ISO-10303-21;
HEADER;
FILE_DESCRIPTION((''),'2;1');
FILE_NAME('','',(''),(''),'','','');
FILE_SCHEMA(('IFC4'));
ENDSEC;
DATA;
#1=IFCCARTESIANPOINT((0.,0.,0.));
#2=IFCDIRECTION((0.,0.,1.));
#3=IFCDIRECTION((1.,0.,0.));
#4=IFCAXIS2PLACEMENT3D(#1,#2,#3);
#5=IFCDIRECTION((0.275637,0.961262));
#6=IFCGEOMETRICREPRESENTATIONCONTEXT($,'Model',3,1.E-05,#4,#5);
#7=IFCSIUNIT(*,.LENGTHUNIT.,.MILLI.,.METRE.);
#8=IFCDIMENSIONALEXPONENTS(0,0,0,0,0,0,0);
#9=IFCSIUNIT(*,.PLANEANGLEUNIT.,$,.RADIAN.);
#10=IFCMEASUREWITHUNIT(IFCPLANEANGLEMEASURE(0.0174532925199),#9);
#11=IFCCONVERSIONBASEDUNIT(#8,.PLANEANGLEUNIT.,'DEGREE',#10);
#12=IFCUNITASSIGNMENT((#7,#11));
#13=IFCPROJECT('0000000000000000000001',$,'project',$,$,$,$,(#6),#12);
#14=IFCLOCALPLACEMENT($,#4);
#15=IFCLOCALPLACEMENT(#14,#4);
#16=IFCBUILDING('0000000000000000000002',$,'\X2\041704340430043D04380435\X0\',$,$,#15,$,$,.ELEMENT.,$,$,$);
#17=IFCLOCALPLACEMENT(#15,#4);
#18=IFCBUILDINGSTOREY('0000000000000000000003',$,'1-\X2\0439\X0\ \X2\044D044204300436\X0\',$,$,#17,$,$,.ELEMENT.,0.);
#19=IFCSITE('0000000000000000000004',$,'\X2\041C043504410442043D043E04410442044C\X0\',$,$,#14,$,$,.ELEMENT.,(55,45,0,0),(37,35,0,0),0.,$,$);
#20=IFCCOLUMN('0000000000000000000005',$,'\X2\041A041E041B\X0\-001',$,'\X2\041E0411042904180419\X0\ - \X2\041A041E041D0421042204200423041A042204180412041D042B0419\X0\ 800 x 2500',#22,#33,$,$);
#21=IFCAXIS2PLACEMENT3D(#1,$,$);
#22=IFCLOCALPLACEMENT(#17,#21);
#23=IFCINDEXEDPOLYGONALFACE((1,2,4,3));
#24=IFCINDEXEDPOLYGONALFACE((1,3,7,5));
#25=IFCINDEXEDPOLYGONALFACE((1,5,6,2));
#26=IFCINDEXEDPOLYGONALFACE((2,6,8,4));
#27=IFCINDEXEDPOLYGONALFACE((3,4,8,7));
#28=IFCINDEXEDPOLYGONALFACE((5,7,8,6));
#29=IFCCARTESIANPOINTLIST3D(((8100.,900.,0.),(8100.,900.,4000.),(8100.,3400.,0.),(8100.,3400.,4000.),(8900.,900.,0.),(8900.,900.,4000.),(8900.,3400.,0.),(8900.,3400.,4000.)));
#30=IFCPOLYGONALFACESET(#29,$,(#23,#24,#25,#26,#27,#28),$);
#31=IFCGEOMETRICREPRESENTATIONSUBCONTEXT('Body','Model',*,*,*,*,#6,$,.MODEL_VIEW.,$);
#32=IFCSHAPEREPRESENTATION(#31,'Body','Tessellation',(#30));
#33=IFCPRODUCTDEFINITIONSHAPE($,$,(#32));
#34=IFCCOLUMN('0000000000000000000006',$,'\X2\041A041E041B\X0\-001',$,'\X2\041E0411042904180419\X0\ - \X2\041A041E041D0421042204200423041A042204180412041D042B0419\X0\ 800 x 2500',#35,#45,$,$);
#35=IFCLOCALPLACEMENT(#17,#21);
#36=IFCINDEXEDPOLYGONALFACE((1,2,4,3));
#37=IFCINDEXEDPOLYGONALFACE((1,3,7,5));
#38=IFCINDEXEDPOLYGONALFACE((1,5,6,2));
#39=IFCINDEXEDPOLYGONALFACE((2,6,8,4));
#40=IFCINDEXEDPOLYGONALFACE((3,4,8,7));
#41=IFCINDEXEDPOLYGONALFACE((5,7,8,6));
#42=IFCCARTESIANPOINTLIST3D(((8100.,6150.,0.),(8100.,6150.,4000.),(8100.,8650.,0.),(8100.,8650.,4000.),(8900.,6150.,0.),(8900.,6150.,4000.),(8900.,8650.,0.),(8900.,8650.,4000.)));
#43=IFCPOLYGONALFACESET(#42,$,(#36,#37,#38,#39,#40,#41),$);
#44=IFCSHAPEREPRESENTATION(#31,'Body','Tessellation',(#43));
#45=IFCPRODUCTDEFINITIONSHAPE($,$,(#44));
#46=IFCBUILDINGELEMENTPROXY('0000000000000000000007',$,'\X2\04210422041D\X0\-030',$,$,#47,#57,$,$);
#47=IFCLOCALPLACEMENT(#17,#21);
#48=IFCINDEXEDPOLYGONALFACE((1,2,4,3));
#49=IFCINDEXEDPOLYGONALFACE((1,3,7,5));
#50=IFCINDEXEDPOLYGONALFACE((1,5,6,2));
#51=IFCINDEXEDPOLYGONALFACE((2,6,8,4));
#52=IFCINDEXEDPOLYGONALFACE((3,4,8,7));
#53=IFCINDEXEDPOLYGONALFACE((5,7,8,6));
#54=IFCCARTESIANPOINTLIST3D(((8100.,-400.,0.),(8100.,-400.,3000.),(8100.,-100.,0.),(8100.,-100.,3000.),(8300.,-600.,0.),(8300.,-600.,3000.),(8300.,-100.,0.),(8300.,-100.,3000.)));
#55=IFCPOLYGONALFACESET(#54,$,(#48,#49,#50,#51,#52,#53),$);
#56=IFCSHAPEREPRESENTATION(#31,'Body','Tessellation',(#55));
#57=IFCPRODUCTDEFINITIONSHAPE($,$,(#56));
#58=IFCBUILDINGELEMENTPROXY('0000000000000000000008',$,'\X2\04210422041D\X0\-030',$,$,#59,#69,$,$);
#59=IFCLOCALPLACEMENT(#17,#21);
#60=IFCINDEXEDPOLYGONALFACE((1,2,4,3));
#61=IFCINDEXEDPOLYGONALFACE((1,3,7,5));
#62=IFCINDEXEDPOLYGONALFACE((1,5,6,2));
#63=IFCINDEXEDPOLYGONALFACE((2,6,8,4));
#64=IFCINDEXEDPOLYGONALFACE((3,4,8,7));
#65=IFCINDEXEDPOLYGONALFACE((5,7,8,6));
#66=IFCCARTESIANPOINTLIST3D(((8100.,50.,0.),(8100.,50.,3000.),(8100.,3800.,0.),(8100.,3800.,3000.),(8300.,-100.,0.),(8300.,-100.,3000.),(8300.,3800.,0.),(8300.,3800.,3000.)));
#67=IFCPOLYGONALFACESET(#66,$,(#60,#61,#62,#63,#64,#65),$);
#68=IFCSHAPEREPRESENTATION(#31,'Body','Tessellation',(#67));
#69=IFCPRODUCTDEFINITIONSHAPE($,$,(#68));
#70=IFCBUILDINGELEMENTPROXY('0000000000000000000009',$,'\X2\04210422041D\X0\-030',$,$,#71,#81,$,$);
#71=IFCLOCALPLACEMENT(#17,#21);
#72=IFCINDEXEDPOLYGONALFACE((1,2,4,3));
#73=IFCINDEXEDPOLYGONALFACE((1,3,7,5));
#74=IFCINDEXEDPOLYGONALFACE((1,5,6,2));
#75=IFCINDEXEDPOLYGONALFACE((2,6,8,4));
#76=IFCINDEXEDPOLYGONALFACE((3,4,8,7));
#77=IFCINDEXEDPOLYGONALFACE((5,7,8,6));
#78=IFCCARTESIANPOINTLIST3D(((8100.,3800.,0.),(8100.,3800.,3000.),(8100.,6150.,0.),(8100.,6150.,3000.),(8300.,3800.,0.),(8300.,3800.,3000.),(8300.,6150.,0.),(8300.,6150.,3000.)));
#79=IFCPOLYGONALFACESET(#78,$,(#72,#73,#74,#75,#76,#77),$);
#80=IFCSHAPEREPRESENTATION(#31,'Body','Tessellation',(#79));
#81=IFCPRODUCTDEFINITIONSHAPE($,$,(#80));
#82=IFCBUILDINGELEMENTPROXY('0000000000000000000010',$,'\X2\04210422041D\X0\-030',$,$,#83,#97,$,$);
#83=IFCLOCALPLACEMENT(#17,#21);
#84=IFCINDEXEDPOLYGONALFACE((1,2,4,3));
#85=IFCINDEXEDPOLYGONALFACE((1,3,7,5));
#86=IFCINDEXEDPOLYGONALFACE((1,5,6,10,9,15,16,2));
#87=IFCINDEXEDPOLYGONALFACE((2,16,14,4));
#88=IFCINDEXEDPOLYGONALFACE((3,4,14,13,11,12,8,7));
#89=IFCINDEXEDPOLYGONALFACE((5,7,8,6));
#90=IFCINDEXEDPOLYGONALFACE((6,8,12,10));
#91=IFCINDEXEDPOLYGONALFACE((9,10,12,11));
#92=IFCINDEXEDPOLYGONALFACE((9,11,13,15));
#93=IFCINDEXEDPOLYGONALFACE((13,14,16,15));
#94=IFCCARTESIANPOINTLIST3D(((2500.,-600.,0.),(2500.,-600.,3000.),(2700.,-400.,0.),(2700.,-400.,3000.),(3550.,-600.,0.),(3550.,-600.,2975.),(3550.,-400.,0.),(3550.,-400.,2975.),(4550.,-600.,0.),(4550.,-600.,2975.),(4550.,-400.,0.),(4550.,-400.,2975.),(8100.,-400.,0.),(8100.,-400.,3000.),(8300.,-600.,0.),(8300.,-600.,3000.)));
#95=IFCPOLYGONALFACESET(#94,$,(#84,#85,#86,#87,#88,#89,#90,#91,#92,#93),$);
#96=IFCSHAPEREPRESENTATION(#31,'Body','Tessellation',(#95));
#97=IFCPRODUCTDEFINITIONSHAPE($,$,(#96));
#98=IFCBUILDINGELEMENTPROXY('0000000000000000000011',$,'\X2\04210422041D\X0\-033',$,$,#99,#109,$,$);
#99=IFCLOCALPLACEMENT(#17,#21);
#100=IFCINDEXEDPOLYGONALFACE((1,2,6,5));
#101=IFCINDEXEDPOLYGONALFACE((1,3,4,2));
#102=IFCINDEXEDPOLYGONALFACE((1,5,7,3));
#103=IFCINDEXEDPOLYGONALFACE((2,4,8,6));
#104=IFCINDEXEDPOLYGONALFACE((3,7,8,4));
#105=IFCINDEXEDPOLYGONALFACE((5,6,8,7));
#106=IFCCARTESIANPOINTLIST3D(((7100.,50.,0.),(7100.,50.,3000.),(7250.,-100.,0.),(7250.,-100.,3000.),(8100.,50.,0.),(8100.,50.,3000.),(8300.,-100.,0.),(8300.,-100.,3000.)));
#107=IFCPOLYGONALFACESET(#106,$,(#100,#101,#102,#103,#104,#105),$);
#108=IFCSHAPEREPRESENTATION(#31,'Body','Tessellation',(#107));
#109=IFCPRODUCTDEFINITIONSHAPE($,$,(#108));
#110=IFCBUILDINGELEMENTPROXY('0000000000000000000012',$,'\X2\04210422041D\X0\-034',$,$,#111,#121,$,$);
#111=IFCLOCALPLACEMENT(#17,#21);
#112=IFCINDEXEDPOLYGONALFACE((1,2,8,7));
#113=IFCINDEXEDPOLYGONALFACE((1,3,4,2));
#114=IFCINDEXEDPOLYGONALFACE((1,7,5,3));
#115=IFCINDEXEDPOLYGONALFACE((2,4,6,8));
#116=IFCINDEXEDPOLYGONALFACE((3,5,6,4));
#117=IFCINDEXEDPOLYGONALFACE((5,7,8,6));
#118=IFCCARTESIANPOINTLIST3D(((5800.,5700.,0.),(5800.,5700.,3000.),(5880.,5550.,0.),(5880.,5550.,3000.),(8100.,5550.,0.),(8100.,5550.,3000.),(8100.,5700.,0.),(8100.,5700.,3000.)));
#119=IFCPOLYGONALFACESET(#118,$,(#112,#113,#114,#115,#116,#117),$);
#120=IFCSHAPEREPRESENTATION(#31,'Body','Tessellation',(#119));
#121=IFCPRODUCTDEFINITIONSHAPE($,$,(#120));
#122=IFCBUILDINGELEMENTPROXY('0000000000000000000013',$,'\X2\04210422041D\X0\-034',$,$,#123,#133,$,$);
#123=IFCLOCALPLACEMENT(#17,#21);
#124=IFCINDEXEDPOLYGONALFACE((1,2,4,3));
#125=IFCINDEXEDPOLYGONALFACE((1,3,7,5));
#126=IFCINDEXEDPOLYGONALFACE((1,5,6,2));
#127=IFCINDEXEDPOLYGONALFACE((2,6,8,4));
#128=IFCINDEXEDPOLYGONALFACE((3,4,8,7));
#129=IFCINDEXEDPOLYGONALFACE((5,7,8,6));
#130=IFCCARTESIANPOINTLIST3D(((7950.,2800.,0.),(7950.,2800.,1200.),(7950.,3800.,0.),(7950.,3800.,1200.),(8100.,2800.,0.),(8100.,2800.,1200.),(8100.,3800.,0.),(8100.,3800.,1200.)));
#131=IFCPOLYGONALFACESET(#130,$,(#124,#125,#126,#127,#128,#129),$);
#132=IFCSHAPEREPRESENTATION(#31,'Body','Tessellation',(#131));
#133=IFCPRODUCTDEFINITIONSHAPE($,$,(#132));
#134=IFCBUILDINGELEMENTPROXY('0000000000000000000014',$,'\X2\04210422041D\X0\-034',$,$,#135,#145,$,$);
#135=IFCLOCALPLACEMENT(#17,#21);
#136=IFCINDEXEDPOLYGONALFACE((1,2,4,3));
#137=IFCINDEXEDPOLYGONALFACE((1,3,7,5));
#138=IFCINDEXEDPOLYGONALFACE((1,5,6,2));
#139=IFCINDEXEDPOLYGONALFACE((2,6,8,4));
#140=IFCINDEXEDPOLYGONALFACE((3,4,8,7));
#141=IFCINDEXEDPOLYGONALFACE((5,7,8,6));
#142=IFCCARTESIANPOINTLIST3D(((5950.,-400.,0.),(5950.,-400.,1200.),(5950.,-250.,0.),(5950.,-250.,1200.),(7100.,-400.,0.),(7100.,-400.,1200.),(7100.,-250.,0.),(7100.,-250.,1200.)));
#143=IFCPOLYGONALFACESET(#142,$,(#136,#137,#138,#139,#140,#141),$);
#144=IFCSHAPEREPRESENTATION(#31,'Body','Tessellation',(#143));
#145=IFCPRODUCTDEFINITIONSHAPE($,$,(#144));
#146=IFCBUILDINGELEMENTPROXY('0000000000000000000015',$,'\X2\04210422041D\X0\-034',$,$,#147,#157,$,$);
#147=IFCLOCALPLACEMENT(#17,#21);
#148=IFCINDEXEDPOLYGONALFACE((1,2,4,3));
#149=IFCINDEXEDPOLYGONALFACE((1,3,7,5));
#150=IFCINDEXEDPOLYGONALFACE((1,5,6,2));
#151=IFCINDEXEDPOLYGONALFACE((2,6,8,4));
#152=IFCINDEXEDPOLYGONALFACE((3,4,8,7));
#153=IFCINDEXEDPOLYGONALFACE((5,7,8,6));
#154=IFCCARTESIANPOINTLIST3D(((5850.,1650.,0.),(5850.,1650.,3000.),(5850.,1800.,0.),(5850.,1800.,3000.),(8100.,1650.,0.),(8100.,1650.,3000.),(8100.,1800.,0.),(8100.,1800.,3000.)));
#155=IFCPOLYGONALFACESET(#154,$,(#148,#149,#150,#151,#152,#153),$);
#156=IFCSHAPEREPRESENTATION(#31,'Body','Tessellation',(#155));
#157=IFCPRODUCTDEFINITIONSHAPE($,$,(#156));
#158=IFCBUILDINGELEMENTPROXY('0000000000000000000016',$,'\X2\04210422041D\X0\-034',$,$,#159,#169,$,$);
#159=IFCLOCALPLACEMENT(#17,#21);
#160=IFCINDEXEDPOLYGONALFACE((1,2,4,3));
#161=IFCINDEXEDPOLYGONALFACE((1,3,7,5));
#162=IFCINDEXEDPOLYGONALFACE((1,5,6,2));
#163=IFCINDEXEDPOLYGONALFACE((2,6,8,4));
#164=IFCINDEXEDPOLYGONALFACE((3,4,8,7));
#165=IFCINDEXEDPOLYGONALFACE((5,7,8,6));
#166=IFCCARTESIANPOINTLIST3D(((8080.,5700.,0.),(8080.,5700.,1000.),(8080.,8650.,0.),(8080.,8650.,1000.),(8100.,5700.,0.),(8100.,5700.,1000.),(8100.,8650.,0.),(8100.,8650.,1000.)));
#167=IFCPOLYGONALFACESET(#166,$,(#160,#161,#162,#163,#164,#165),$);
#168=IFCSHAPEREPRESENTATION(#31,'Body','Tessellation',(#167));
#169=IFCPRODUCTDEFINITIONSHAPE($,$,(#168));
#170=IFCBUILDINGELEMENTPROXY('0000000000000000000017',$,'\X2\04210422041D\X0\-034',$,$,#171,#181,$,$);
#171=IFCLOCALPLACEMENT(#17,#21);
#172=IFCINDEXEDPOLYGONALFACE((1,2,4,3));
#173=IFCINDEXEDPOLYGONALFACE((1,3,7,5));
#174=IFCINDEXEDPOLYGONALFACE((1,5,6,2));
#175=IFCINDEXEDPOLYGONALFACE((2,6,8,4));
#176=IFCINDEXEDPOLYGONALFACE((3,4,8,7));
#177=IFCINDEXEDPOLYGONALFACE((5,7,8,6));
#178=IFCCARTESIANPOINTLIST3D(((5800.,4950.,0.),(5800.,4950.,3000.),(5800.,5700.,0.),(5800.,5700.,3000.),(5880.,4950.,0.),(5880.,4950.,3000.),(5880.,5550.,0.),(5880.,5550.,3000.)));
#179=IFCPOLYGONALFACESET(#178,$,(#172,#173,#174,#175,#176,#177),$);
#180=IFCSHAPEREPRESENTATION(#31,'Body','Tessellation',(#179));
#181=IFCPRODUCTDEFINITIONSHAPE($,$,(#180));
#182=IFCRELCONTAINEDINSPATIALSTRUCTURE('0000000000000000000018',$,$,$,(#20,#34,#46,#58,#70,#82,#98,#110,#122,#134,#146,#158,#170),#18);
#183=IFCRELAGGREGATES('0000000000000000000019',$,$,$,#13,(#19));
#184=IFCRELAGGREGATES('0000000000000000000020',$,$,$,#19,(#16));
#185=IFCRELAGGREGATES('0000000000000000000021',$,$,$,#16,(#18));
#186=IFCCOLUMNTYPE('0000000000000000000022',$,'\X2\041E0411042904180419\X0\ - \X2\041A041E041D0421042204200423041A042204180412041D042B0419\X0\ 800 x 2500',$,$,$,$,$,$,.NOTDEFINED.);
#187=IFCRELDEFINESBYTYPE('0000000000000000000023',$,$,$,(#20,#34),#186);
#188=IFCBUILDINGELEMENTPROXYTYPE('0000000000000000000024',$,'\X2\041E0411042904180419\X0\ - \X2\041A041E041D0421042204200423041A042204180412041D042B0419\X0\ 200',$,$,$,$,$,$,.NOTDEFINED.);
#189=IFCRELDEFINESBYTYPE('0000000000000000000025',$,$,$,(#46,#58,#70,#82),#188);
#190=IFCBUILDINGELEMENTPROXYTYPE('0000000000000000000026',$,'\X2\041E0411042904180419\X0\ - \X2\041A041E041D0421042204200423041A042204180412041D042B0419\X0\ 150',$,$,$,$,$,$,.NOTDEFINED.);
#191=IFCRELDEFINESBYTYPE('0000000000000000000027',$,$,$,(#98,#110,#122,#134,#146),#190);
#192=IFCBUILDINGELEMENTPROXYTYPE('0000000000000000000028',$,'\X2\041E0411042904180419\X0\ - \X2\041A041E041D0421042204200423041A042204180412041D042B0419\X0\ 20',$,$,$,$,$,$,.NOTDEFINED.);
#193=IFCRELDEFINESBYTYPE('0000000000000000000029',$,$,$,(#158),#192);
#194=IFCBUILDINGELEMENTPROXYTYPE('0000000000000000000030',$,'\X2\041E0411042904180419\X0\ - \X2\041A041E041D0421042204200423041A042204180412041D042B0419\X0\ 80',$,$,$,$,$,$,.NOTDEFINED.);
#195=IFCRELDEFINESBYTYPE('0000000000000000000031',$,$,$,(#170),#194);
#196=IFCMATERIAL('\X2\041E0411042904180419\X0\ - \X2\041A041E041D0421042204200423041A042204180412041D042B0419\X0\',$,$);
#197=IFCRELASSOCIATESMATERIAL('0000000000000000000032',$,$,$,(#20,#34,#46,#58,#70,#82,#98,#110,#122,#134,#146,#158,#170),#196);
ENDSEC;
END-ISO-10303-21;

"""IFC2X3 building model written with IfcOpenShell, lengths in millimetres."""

from ifc_helpers import new_model, entity, si_unit, converted_unit, direction, frame, origin_with_axes, origin_2d_with_axis, place, context, subcontext, project, spatial, polyline, rectangle, outline, extrude, material, type_object, element, save


model = new_model("IFC2X3")

# Units and contexts
model_context = context("Model", 3, precision=1e-05, world=origin_with_axes(), true_north=direction((0.275637, 0.961262)))
body_context = subcontext(model_context, "Body", "Model", "MODEL_VIEW")
ifc_project = project(units=[si_unit("LENGTHUNIT", "METRE", prefix="MILLI"), converted_unit("PLANEANGLEUNIT", "DEGREE", entity("IfcPlaneAngleMeasure", 0.0174532925199), si_unit("PLANEANGLEUNIT", "RADIAN"), dimensions=[0, 0, 0, 0, 0, 0, 0])], contexts=[model_context])

# Site, building, storey
site_placement = place(None, origin_with_axes())
site = spatial("IfcSite", under=ifc_project, at=site_placement, Name="Местность", CompositionType="ELEMENT", RefLatitude=(55, 45, 0, 0), RefLongitude=(37, 35, 0, 0), RefElevation=0.0)
building_placement = place(site_placement, origin_with_axes())
building = spatial("IfcBuilding", under=site, at=building_placement, Name="Здание", CompositionType="ELEMENT")
storey_placement = place(building_placement, origin_with_axes())
storey = spatial("IfcBuildingStorey", under=building, at=storey_placement, Name="1-й этаж", CompositionType="ELEMENT", Elevation=0.0)

# Columns
ifc_material_1 = material(Name="ОБЩИЙ - КОНСТРУКТИВНЫЙ")
column_type = type_object("IfcColumnType", Name="ОБЩИЙ - КОНСТРУКТИВНЫЙ 800 x 2500", PredefinedType="NOTDEFINED")
for number, where, z_axis, x_axis, name in (
    (1, (8500.0, 2150.0, 0.0), (0.0, 0.0, 1.0), (1.0, 0.0, 0.0), "КОЛ-001"),
    (2, (8500.0, 7400.0, 0.0), (0.0, 0.0, 1.0), (1.0, 0.0, 0.0), "КОЛ-001"),
):
    element("IfcColumn", number, at=place(storey_placement, frame(where, z_axis=z_axis, x_axis=x_axis)), inside=storey, type_object=column_type, material=ifc_material_1, Name=name, ObjectType="ОБЩИЙ - КОНСТРУКТИВНЫЙ 800 x 2500", context=body_context, shape_type="SweptSolid", body=[
        extrude(rectangle(XDim=800.0, YDim=2500.0, at=origin_2d_with_axis()), origin_with_axes(), (0.0, 0.0, 1.0), 4000.0),
    ])

# Building element proxies
building_element_proxy_type_1 = type_object("IfcBuildingElementProxyType", Name="ОБЩИЙ - КОНСТРУКТИВНЫЙ 200", PredefinedType="NOTDEFINED")
proxy_1_placement = place(storey_placement, frame((8100.0, -100.0, 0.0), z_axis=(0.0, 0.0, 1.0), x_axis=(0.0, -1.0, 0.0)))
element("IfcBuildingElementProxy", 3, at=proxy_1_placement, inside=storey, type_object=building_element_proxy_type_1, material=ifc_material_1, Name="СТН-030", context=body_context, shape_type="SweptSolid", body=[
    extrude(outline(polyline([(0.0, 0.0), (300.0, 0.0), (500.0, 200.0), (0.0, 200.0), (0.0, 0.0)])), origin_with_axes(), (0.0, 0.0, 1.0), 3000.0),
])
proxy_2_placement = place(storey_placement, frame((8300.0, 3800.0, 0.0), z_axis=(0.0, 0.0, 1.0), x_axis=(0.0, -1.0, 0.0)))
element("IfcBuildingElementProxy", 4, at=proxy_2_placement, inside=storey, type_object=building_element_proxy_type_1, material=ifc_material_1, Name="СТН-030", context=body_context, shape_type="SweptSolid", body=[
    extrude(outline(polyline([(0.0, -200.0), (3750.0, -200.0), (3900.0, 0.0), (0.0, 0.0), (0.0, -200.0)])), origin_with_axes(), (0.0, 0.0, 1.0), 3000.0),
])
proxy_3_placement = place(storey_placement, frame((8300.0, 6150.0, 0.0), z_axis=(0.0, 0.0, 1.0), x_axis=(0.0, -1.0, 0.0)))
element("IfcBuildingElementProxy", 5, at=proxy_3_placement, inside=storey, type_object=building_element_proxy_type_1, material=ifc_material_1, Name="СТН-030", context=body_context, shape_type="SweptSolid", body=[
    extrude(outline(polyline([(0.0, -200.0), (2350.0, -200.0), (2350.0, 0.0), (0.0, 0.0), (0.0, -200.0)])), origin_with_axes(), (0.0, 0.0, 1.0), 3000.0),
])

# Building element proxy, opening
proxy_4_placement = place(storey_placement, frame((8100.0, -600.0, 0.0), z_axis=(0.0, 0.0, 1.0), x_axis=(-1.0, 0.0, 0.0)))
proxy_4 = element("IfcBuildingElementProxy", 6, at=proxy_4_placement, inside=storey, type_object=building_element_proxy_type_1, material=ifc_material_1, Name="СТН-030", context=body_context, shape_type="SweptSolid", body=[
    extrude(outline(polyline([(0.0, -200.0), (5400.0, -200.0), (5600.0, 0.0), (-200.0, 0.0), (0.0, -200.0)])), origin_with_axes(), (0.0, 0.0, 1.0), 3000.0),
])
opening_1_placement = place(proxy_4_placement, frame((4050.0, 0.0, 0.0), z_axis=(0.0, 0.0, 1.0), x_axis=(1.0, 0.0, 0.0)))
element("IfcOpeningElement", 7, at=opening_1_placement, cuts=proxy_4, context=body_context, shape_type="SweptSolid", body=[
    extrude(rectangle(XDim=1000.0, YDim=2975.0, at=origin_2d_with_axis()), frame((0.0, 200.0, 1487.5), z_axis=(0.0, 1.0, 0.0), x_axis=(1.0, 0.0, 0.0)), (0.0, 0.0, -1.0), 600.0),
    extrude(rectangle(XDim=1044.0, YDim=2997.0, at=origin_2d_with_axis()), frame((0.0, 0.0, 1498.5), z_axis=(0.0, 1.0, 0.0), x_axis=(1.0, 0.0, 0.0)), (0.0, 0.0, 1.0), 200.0),
    extrude(rectangle(XDim=1044.0, YDim=2997.0, at=origin_2d_with_axis()), frame((0.0, -200.0, 1498.5), z_axis=(0.0, -1.0, 0.0), x_axis=(1.0, 0.0, 0.0)), (0.0, 0.0, 1.0), 200.0),
])

# Building element proxies
building_element_proxy_type_2 = type_object("IfcBuildingElementProxyType", Name="ОБЩИЙ - КОНСТРУКТИВНЫЙ 150", PredefinedType="NOTDEFINED")
proxy_5_placement = place(storey_placement, frame((7250.0, -100.0, 0.0), z_axis=(0.0, 0.0, 1.0), x_axis=(1.0, 0.0, 0.0)))
element("IfcBuildingElementProxy", 8, at=proxy_5_placement, inside=storey, type_object=building_element_proxy_type_2, material=ifc_material_1, Name="СТН-033", context=body_context, shape_type="SweptSolid", body=[
    extrude(outline(polyline([(0.0, 0.0), (1050.0, 0.0), (850.0, 150.0), (-150.0, 150.0), (0.0, 0.0)])), origin_with_axes(), (0.0, 0.0, 1.0), 3000.0),
])
proxy_6_placement = place(storey_placement, frame((5800.0, 5550.0, 0.0), z_axis=(0.0, 0.0, 1.0), x_axis=(1.0, 0.0, 0.0)))
element("IfcBuildingElementProxy", 9, at=proxy_6_placement, inside=storey, type_object=building_element_proxy_type_2, material=ifc_material_1, Name="СТН-034", context=body_context, shape_type="SweptSolid", body=[
    extrude(outline(polyline([(80.0, 0.0), (2300.0, 0.0), (2300.0, 150.0), (0.0, 150.0), (80.0, 0.0)])), origin_with_axes(), (0.0, 0.0, 1.0), 3000.0),
])
proxy_7_placement = place(storey_placement, frame((8100.0, 2800.0, 0.0), z_axis=(0.0, 0.0, 1.0), x_axis=(0.0, 1.0, 0.0)))
element("IfcBuildingElementProxy", 10, at=proxy_7_placement, inside=storey, type_object=building_element_proxy_type_2, material=ifc_material_1, Name="СТН-034", context=body_context, shape_type="SweptSolid", body=[
    extrude(outline(polyline([(0.0, 0.0), (1000.0, 0.0), (1000.0, 150.0), (0.0, 150.0), (0.0, 0.0)])), origin_with_axes(), (0.0, 0.0, 1.0), 1200.0),
])
proxy_8_placement = place(storey_placement, frame((5950.0, -400.0, 0.0), z_axis=(0.0, 0.0, 1.0), x_axis=(1.0, 0.0, 0.0)))
element("IfcBuildingElementProxy", 11, at=proxy_8_placement, inside=storey, type_object=building_element_proxy_type_2, material=ifc_material_1, Name="СТН-034", context=body_context, shape_type="SweptSolid", body=[
    extrude(outline(polyline([(0.0, 0.0), (1150.0, 0.0), (1150.0, 150.0), (0.0, 150.0), (0.0, 0.0)])), origin_with_axes(), (0.0, 0.0, 1.0), 1200.0),
])
proxy_9_placement = place(storey_placement, frame((5850.0, 1800.0, 0.0), z_axis=(0.0, 0.0, 1.0), x_axis=(1.0, 0.0, 0.0)))
element("IfcBuildingElementProxy", 12, at=proxy_9_placement, inside=storey, type_object=building_element_proxy_type_2, material=ifc_material_1, Name="СТН-034", context=body_context, shape_type="SweptSolid", body=[
    extrude(outline(polyline([(0.0, -150.0), (2250.0, -150.0), (2250.0, 0.0), (0.0, 0.0), (0.0, -150.0)])), origin_with_axes(), (0.0, 0.0, 1.0), 3000.0),
])

# Building element proxies
building_element_proxy_type_3 = type_object("IfcBuildingElementProxyType", Name="ОБЩИЙ - КОНСТРУКТИВНЫЙ 20", PredefinedType="NOTDEFINED")
proxy_10_placement = place(storey_placement, frame((8100.0, 5700.0, 0.0), z_axis=(0.0, 0.0, 1.0), x_axis=(0.0, 1.0, 0.0)))
element("IfcBuildingElementProxy", 13, at=proxy_10_placement, inside=storey, type_object=building_element_proxy_type_3, material=ifc_material_1, Name="СТН-034", context=body_context, shape_type="SweptSolid", body=[
    extrude(outline(polyline([(0.0, 0.0), (2950.0, 0.0), (2950.0, 20.0), (0.0, 20.0), (0.0, 0.0)])), origin_with_axes(), (0.0, 0.0, 1.0), 1000.0),
])
building_element_proxy_type_4 = type_object("IfcBuildingElementProxyType", Name="ОБЩИЙ - КОНСТРУКТИВНЫЙ 80", PredefinedType="NOTDEFINED")
proxy_11_placement = place(storey_placement, frame((5800.0, 5550.0, 0.0), z_axis=(0.0, 0.0, 1.0), x_axis=(0.0, -1.0, 0.0)))
element("IfcBuildingElementProxy", 14, at=proxy_11_placement, inside=storey, type_object=building_element_proxy_type_4, material=ifc_material_1, Name="СТН-034", context=body_context, shape_type="SweptSolid", body=[
    extrude(outline(polyline([(-150.0, 0.0), (600.0, 0.0), (600.0, 80.0), (0.0, 80.0), (-150.0, 0.0)])), origin_with_axes(), (0.0, 0.0, 1.0), 3000.0),
])

save(model, "model.ifc")
